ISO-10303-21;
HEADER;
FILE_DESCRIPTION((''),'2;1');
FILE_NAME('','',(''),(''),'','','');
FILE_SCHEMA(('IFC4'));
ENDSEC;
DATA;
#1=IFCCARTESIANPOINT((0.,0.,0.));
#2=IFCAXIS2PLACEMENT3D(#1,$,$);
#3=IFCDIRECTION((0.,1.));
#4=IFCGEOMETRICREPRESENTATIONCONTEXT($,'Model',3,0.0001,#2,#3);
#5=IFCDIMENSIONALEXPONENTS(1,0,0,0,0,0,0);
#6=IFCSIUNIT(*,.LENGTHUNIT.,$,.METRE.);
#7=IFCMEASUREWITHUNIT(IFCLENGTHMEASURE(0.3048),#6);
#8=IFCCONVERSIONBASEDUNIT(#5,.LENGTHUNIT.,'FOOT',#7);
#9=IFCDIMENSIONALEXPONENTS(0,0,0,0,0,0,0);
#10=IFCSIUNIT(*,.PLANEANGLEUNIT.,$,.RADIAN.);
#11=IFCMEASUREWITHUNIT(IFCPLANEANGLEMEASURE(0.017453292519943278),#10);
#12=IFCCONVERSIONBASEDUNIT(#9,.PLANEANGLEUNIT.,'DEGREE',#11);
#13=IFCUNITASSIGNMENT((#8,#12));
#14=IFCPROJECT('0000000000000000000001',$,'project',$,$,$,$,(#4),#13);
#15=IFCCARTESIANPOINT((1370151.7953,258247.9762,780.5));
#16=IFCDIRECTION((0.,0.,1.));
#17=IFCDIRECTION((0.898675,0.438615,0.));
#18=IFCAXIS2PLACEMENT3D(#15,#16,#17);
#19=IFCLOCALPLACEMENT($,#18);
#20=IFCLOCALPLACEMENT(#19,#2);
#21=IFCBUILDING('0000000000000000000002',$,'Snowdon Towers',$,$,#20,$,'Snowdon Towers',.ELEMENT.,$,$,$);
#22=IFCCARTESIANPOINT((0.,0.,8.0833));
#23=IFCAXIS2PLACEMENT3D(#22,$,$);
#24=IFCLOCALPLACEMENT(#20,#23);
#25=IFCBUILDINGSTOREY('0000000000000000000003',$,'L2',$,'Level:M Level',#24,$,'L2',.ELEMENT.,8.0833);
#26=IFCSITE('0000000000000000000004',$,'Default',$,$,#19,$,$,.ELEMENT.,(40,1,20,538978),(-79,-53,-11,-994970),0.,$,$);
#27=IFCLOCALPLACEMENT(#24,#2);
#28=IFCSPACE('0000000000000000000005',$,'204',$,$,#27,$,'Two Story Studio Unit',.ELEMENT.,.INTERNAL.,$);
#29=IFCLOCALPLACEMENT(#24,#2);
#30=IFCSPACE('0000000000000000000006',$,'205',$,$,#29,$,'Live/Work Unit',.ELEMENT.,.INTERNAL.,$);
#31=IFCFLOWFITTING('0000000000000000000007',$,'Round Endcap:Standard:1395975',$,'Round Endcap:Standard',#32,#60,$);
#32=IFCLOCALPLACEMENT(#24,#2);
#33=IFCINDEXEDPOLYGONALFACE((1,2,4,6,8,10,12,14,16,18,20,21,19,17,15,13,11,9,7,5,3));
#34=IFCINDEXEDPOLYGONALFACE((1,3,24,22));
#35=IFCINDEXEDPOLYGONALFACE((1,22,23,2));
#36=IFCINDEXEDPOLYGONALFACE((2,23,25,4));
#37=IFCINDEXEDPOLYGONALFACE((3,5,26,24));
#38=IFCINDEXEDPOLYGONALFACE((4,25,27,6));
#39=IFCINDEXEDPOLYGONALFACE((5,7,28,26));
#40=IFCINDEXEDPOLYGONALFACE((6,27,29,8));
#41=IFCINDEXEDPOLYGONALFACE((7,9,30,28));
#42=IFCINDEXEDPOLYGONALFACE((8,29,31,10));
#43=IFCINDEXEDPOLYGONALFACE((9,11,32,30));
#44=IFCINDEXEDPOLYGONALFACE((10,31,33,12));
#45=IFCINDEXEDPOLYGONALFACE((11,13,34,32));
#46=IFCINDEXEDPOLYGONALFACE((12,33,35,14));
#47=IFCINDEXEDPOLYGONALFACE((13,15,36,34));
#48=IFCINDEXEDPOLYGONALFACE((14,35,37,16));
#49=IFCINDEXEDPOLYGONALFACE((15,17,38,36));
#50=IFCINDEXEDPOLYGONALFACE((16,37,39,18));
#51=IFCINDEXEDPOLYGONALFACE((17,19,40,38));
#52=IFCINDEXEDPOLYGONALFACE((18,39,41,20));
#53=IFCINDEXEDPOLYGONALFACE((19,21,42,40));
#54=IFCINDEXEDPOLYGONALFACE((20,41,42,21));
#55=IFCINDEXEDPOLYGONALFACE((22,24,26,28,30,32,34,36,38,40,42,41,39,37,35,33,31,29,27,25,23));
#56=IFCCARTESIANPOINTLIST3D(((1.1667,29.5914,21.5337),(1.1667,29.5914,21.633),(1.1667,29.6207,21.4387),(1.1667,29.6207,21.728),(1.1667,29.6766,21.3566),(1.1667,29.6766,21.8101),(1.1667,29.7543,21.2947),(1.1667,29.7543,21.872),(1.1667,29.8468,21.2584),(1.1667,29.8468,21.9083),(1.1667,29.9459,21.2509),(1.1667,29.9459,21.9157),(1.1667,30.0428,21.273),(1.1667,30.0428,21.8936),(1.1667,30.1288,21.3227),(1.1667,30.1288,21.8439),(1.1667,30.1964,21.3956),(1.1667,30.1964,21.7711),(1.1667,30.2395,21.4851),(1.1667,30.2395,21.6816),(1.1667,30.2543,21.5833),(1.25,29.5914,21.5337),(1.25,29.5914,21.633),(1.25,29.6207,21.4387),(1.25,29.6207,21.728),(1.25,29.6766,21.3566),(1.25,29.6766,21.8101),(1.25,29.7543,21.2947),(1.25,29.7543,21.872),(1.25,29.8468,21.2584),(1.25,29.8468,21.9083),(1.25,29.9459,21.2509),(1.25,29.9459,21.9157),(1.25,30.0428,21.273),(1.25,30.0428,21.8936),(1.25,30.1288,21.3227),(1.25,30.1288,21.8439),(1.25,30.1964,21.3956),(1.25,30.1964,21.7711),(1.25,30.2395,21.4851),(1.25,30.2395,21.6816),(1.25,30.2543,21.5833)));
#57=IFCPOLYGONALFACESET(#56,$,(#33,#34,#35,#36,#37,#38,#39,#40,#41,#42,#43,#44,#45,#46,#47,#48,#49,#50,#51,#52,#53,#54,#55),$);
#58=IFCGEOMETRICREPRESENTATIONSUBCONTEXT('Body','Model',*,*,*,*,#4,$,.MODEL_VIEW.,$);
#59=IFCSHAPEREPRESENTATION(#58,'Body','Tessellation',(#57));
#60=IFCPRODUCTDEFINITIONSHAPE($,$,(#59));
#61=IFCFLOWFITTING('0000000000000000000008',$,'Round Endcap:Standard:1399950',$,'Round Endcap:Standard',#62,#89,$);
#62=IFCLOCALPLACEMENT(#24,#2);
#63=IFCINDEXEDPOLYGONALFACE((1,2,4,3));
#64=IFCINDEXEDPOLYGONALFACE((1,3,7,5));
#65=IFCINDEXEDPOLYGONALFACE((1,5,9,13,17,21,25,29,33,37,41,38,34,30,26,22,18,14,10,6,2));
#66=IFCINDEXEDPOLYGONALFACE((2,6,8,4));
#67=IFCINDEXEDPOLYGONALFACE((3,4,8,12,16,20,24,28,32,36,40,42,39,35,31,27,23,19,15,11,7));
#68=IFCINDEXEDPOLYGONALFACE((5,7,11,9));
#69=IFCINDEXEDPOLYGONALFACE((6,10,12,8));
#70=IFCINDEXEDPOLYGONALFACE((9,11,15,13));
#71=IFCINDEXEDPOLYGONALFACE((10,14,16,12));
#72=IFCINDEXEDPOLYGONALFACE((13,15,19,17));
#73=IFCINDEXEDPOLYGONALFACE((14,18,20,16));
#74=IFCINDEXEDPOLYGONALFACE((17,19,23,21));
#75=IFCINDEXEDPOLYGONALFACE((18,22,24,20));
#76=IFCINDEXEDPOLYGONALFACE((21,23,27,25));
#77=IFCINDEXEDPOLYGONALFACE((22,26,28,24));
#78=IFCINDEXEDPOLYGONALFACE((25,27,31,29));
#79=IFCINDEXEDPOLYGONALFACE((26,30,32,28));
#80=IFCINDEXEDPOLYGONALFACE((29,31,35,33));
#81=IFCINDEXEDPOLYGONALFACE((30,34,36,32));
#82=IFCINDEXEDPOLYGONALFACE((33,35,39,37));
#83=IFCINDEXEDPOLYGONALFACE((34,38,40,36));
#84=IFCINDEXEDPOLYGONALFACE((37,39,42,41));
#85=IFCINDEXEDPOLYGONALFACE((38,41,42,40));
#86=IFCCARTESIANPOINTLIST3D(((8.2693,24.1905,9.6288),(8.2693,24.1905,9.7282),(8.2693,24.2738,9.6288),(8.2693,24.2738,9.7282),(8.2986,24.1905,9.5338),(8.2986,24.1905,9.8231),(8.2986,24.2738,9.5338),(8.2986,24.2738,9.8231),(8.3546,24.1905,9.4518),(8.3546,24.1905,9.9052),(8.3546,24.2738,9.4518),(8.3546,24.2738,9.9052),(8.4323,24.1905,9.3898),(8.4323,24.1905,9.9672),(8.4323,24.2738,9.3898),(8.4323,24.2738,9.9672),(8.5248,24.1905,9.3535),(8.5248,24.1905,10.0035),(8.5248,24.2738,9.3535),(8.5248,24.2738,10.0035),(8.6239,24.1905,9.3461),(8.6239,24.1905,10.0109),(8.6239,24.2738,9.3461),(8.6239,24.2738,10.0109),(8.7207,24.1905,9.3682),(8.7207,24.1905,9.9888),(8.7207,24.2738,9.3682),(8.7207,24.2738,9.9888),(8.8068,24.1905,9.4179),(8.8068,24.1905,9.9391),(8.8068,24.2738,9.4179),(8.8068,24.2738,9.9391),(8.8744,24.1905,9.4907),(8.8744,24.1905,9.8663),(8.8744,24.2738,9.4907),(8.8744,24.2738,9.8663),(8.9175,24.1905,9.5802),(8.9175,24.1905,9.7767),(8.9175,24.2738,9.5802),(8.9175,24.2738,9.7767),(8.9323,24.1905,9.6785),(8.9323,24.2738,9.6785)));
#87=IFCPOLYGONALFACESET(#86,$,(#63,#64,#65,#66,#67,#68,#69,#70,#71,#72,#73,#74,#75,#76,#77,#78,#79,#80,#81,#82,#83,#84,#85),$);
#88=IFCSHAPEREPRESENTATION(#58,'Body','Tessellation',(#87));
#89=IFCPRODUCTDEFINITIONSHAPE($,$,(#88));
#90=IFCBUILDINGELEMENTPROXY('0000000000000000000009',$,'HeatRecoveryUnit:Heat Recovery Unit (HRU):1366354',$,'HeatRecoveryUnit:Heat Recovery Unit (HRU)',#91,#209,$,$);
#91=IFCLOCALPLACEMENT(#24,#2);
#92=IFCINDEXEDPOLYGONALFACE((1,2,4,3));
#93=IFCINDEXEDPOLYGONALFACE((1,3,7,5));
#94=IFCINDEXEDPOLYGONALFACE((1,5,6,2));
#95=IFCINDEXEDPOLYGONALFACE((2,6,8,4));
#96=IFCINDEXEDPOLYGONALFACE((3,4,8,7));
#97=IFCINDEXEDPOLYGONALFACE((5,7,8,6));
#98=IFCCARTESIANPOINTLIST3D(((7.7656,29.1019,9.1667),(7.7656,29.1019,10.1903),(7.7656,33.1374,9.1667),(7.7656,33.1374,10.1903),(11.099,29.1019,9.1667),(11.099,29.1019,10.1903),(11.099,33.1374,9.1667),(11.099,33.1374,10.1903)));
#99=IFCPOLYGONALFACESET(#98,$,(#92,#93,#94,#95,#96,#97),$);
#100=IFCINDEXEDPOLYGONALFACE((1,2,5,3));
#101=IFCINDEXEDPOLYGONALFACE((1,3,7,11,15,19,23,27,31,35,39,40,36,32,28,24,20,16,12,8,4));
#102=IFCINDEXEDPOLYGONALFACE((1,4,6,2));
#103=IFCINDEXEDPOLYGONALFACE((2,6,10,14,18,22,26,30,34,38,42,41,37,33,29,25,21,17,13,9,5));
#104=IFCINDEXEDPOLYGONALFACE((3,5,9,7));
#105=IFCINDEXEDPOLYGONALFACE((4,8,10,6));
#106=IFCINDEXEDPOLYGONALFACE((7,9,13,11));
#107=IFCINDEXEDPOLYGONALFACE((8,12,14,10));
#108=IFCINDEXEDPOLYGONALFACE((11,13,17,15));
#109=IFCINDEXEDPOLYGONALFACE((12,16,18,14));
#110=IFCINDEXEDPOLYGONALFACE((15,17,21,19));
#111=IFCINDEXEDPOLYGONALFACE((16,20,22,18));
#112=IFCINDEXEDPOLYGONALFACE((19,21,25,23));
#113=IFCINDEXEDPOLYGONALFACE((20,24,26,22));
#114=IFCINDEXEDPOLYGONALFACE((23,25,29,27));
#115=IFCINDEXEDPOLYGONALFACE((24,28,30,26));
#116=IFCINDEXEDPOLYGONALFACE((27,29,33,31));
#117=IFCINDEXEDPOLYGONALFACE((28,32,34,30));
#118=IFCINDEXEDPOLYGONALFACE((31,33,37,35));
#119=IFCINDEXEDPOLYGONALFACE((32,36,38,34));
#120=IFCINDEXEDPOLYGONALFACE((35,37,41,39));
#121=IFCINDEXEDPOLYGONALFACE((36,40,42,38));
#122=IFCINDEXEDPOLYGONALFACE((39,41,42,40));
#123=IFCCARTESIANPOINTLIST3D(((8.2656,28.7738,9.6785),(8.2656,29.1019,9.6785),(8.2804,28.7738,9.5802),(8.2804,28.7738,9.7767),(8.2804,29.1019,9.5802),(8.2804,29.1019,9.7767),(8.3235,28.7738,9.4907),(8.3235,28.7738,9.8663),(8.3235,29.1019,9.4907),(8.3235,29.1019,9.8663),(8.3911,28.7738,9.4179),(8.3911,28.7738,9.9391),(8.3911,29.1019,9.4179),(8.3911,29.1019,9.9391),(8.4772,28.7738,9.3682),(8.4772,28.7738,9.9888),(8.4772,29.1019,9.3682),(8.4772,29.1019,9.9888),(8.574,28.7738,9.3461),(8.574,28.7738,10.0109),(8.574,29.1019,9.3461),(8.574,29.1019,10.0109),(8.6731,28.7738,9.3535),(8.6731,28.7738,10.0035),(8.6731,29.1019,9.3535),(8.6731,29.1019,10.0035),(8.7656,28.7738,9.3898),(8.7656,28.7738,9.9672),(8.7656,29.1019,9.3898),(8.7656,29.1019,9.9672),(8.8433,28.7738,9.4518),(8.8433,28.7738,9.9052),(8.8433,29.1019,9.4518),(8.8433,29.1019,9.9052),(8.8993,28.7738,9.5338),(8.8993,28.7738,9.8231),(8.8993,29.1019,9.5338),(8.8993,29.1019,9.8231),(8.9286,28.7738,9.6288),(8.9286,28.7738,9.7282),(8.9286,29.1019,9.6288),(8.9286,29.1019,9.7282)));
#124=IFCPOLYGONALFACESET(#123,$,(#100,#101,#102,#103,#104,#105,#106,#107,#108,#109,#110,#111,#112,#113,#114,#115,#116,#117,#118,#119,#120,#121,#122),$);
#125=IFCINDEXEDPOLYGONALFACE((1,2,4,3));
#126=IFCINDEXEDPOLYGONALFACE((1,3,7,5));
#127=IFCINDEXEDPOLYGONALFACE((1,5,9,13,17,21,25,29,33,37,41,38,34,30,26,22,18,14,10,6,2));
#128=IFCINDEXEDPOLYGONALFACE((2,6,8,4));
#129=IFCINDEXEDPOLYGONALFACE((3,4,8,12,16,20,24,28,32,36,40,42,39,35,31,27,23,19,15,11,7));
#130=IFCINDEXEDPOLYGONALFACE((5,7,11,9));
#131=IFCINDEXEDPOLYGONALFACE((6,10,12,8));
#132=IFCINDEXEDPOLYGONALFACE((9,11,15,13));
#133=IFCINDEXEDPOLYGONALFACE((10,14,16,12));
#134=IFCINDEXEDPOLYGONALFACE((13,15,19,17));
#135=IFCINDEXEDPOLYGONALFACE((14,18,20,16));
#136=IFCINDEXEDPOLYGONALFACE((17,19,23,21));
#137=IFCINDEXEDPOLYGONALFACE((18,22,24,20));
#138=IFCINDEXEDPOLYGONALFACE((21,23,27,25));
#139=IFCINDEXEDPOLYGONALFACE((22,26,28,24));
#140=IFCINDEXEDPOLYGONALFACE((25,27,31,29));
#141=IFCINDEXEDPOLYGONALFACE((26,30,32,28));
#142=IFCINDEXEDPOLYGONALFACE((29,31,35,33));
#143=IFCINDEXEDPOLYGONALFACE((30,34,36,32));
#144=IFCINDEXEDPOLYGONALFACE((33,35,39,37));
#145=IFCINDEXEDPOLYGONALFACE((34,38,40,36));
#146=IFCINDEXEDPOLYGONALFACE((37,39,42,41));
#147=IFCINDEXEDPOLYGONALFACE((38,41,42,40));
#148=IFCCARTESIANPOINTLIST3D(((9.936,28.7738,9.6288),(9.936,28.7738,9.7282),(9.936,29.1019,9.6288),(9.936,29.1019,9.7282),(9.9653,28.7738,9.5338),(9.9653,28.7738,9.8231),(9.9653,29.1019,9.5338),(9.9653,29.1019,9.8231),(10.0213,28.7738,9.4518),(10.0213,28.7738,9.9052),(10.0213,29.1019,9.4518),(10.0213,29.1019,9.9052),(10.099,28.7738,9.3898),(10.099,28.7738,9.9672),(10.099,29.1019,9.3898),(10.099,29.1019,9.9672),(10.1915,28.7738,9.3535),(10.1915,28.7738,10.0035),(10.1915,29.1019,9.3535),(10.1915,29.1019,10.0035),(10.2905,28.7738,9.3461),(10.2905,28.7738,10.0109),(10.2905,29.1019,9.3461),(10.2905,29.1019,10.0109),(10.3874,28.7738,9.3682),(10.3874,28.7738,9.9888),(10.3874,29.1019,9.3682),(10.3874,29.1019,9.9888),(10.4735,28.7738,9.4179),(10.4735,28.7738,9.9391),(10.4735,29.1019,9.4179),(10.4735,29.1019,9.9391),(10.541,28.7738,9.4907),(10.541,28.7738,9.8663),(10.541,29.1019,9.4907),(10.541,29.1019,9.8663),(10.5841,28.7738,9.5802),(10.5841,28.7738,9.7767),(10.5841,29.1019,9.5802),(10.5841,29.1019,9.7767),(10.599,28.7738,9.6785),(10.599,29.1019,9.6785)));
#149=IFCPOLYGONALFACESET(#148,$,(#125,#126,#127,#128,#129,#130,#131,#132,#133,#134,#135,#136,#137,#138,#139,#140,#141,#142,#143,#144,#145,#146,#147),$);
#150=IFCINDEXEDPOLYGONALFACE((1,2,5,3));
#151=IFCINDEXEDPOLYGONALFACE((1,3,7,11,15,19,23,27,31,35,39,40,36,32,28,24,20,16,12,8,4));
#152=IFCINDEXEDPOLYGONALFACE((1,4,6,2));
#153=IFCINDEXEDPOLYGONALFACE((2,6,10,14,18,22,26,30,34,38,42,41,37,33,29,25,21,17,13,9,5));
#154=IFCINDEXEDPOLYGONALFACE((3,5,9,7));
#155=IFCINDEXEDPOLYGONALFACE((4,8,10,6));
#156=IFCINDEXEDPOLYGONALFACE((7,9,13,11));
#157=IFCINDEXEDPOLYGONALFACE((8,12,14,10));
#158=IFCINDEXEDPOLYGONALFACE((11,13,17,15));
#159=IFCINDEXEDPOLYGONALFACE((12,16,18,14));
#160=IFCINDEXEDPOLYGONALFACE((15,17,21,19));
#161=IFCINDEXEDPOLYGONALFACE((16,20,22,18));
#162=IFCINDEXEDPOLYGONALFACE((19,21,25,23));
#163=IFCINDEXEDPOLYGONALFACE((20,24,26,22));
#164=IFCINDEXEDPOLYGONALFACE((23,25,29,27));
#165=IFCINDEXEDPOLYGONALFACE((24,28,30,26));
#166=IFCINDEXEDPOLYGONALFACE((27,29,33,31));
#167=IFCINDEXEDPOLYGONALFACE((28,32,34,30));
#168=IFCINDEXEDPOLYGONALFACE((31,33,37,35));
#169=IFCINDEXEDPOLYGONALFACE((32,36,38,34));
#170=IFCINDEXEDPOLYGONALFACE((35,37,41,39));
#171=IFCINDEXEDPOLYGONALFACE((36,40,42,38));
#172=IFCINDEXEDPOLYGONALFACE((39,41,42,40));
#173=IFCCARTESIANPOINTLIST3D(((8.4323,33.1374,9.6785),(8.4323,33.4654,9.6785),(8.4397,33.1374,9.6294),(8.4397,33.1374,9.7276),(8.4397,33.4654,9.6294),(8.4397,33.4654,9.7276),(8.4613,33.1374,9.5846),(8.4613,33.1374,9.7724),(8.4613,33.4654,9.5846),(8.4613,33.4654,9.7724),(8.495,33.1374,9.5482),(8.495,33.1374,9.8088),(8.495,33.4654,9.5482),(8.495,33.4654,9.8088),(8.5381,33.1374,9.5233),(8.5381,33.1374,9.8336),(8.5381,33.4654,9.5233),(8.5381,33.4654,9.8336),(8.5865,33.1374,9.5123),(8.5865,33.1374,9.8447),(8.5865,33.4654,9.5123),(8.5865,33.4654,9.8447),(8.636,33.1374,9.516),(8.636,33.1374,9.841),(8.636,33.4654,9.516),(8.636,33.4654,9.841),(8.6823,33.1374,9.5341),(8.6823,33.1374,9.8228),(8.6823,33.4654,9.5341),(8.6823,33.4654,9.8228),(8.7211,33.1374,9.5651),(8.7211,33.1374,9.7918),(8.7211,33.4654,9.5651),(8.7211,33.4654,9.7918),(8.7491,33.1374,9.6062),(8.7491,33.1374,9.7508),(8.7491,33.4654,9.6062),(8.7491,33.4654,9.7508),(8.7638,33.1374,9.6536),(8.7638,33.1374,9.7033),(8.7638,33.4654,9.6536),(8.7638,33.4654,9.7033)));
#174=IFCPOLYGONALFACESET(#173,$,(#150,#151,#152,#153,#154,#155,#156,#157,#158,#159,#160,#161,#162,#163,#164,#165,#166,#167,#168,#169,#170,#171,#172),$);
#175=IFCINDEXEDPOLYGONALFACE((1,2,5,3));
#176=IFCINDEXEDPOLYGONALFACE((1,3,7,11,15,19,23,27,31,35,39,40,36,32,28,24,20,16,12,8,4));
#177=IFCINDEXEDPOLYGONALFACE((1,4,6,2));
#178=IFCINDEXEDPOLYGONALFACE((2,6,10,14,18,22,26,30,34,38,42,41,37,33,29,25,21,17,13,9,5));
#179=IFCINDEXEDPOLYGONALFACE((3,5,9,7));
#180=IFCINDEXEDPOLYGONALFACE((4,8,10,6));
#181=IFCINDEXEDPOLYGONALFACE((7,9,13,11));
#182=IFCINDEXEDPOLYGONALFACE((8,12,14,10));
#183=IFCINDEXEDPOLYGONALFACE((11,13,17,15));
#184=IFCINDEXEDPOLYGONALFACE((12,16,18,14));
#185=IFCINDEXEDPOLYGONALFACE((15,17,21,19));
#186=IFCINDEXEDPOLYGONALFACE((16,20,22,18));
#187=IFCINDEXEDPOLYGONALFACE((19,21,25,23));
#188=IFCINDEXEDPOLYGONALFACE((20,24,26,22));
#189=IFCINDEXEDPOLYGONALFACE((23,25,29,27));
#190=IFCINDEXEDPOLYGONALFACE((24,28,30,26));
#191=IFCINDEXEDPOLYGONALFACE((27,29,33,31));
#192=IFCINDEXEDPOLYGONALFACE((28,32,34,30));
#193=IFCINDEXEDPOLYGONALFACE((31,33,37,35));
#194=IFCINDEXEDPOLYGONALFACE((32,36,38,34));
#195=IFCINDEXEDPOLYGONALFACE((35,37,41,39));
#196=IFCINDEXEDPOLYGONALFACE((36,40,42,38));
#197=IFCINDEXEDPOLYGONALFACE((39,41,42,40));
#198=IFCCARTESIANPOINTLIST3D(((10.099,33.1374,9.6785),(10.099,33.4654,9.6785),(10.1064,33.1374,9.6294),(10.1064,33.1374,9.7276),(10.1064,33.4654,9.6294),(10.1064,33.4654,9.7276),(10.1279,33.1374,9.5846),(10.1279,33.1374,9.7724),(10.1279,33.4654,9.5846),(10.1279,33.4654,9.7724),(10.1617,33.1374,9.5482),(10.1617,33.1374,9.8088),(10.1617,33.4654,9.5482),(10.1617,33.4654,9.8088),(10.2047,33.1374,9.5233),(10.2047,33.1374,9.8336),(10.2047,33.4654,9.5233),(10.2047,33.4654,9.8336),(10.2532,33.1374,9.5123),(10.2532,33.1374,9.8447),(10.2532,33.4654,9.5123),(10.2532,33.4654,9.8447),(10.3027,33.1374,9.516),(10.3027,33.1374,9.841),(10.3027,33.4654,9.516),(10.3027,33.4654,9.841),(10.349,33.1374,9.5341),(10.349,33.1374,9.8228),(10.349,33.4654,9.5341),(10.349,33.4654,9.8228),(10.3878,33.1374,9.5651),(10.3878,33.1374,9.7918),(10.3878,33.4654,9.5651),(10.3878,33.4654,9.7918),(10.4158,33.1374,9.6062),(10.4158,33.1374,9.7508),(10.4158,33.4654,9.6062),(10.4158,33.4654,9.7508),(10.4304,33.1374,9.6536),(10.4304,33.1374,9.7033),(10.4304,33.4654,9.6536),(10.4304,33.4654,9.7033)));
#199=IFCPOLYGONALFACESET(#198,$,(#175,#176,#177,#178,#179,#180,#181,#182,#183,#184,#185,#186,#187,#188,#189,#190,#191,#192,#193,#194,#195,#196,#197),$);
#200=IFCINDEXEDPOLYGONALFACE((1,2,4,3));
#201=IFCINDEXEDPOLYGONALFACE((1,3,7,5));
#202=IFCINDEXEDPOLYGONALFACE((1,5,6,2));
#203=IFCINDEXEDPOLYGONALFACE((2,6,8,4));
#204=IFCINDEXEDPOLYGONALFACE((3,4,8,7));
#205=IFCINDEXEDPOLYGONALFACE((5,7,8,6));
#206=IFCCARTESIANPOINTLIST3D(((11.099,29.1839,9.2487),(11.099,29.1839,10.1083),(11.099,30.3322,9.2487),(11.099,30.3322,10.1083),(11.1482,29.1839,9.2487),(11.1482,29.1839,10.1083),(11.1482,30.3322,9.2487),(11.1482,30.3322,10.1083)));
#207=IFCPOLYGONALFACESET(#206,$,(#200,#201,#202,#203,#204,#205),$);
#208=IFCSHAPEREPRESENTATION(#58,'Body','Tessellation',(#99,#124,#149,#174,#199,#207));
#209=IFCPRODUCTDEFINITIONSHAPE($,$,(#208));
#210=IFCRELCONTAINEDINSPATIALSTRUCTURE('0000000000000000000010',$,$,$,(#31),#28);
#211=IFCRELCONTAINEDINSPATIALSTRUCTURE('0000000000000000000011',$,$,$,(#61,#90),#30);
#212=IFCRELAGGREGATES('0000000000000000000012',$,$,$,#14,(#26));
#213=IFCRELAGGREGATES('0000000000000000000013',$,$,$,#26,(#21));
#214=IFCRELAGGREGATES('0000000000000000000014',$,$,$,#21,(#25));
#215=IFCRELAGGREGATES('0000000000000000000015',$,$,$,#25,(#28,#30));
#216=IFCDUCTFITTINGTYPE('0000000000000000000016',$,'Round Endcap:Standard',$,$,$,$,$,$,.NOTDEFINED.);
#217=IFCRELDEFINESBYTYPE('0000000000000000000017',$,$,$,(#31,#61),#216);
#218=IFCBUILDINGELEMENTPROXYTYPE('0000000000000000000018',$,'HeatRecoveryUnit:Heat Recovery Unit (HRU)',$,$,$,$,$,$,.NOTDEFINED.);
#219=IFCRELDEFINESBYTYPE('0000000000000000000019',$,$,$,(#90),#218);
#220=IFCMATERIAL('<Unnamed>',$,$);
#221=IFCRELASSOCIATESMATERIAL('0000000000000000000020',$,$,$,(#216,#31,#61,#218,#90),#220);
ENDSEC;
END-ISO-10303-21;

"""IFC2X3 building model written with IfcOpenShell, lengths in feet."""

from ifc_helpers import new_model, entity, si_unit, converted_unit, direction, frame, frame_2d, origin, origin_2d_with_axis, place, context, subcontext, project, spatial, rectangle, circle, extrude, source, transform, mapped, material, type_object, type_shapes, element, save


model = new_model("IFC2X3")

# Units and contexts
model_context = context("Model", 3, precision=0.0001, world=origin(), true_north=direction((0.0, 1.0)))
body_context = subcontext(model_context, "Body", "Model", "MODEL_VIEW")
ifc_project = project(units=[converted_unit("LENGTHUNIT", "FOOT", entity("IfcLengthMeasure", 0.3048), si_unit("LENGTHUNIT", "METRE"), dimensions=[1, 0, 0, 0, 0, 0, 0]), converted_unit("PLANEANGLEUNIT", "DEGREE", entity("IfcPlaneAngleMeasure", 0.017453292519943278), si_unit("PLANEANGLEUNIT", "RADIAN"), dimensions=[0, 0, 0, 0, 0, 0, 0])], contexts=[model_context])

# Site, building, storey
site_placement = place(None, frame((1370151.7953, 258247.9762, 780.5), z_axis=(0.0, 0.0, 1.0), x_axis=(0.898675, 0.438615, 0.0)))
site = spatial("IfcSite", under=ifc_project, at=site_placement, Name="Default", CompositionType="ELEMENT", RefLatitude=(40, 1, 20, 538978), RefLongitude=(-79, -53, -11, -994970), RefElevation=0.0)
building_placement = place(site_placement, origin())
building = spatial("IfcBuilding", under=site, at=building_placement, Name="Snowdon Towers", LongName="Snowdon Towers", CompositionType="ELEMENT")
storey_placement = place(building_placement, frame((0.0, 0.0, 8.0833)))
storey = spatial("IfcBuildingStorey", under=building, at=storey_placement, Name="L2", ObjectType="Level:M Level", LongName="L2", CompositionType="ELEMENT", Elevation=8.0833)

# Shared definitions
ifc_material = material(Name="<Unnamed>")

# Shared definitions
space_1_placement = place(storey_placement, origin())
space_1 = spatial("IfcSpace", under=storey, at=space_1_placement, Name="204", LongName="Two Story Studio Unit", CompositionType="ELEMENT", InteriorOrExteriorSpace="INTERNAL")

# Flow fitting
duct_fitting_type = type_object("IfcDuctFittingType", Name="Round Endcap:Standard", PredefinedType="NOTDEFINED", material=ifc_material)
shared_shape_1 = source(origin(), body_context, "Body", "SweptSolid", [
    extrude(circle(Radius=0.3333, at=frame_2d((0.0, 0.0), x_axis=(1.0, 0.0))), frame((0.0, 0.0, 0.0), z_axis=(1.0, 0.0, 0.0), x_axis=(0.0, 1.0, 0.0)), (0.0, 0.0, 1.0), 0.0833),
])
type_shapes(duct_fitting_type, [shared_shape_1])
flow_fitting_1_placement = place(space_1_placement, frame((1.1667, 29.921, 21.5833)))
element("IfcFlowFitting", 1, at=flow_fitting_1_placement, inside=space_1, type_object=duct_fitting_type, material=ifc_material, Name="Round Endcap:Standard:1395975", ObjectType="Round Endcap:Standard", context=body_context, shape_type="MappedRepresentation", body=[
    mapped(shared_shape_1, transform((0.0, 0.0, 0.0), scale=1.0)),
])

# Shared definitions
space_2_placement = place(storey_placement, origin())
space_2 = spatial("IfcSpace", under=storey, at=space_2_placement, Name="205", LongName="Live/Work Unit", CompositionType="ELEMENT", InteriorOrExteriorSpace="INTERNAL")

# Flow fitting
flow_fitting_2_placement = place(space_2_placement, frame((8.599, 24.2738, 9.6785), z_axis=(0.0, 0.0, 1.0), x_axis=(0.0, -1.0, 0.0)))
element("IfcFlowFitting", 2, at=flow_fitting_2_placement, inside=space_2, type_object=duct_fitting_type, material=ifc_material, Name="Round Endcap:Standard:1399950", ObjectType="Round Endcap:Standard", context=body_context, shape_type="MappedRepresentation", body=[
    mapped(shared_shape_1, transform((0.0, 0.0, 0.0), scale=1.0)),
])

# Building element proxy
building_element_proxy_type = type_object("IfcBuildingElementProxyType", Name="HeatRecoveryUnit:Heat Recovery Unit (HRU)", PredefinedType="NOTDEFINED", material=ifc_material)
shared_shape_2 = source(origin(), body_context, "Body", "SweptSolid", [
    extrude(rectangle(XDim=3.3333, YDim=4.0354, at=origin_2d_with_axis()), frame((0.0, 0.0, 0.0), z_axis=(0.0, 0.0, 1.0), x_axis=(-1.0, 0.0, 0.0)), (0.0, 0.0, 1.0), 1.0236),
    extrude(circle(Radius=0.3333, at=frame_2d((0.0, 0.0), x_axis=(1.0, 0.0))), frame((-0.8333, -2.3458, 0.5118), z_axis=(0.0, 1.0, 0.0), x_axis=(-1.0, 0.0, 0.0)), (0.0, 0.0, 1.0), 0.3281),
    extrude(circle(Radius=0.3333, at=frame_2d((0.0, 0.0), x_axis=(1.0, 0.0))), frame((0.8333, -2.3458, 0.5118), z_axis=(0.0, 1.0, 0.0), x_axis=(1.0, 0.0, 0.0)), (0.0, 0.0, 1.0), 0.3281),
    extrude(circle(Radius=0.1667, at=frame_2d((0.0, 0.0), x_axis=(1.0, 0.0))), frame((-0.8333, 2.0177, 0.5118), z_axis=(0.0, 1.0, 0.0), x_axis=(-1.0, 0.0, 0.0)), (0.0, 0.0, 1.0), 0.3281),
    extrude(circle(Radius=0.1667, at=frame_2d((0.0, 0.0), x_axis=(1.0, 0.0))), frame((0.8333, 2.0177, 0.5118), z_axis=(0.0, 1.0, 0.0), x_axis=(-1.0, 0.0, 0.0)), (0.0, 0.0, 1.0), 0.3281),
    extrude(rectangle(XDim=0.0492, YDim=1.1483, at=origin_2d_with_axis()), frame((1.6913, -1.3615, 0.082), z_axis=(0.0, 0.0, 1.0), x_axis=(-1.0, 0.0, 0.0)), (0.0, 0.0, 1.0), 0.8596),
])
type_shapes(building_element_proxy_type, [shared_shape_2])
proxy_placement = place(space_2_placement, frame((9.4323, 31.1196, 9.1667)))
element("IfcBuildingElementProxy", 3, at=proxy_placement, inside=space_2, type_object=building_element_proxy_type, material=ifc_material, Name="HeatRecoveryUnit:Heat Recovery Unit (HRU):1366354", ObjectType="HeatRecoveryUnit:Heat Recovery Unit (HRU)", context=body_context, shape_type="MappedRepresentation", body=[
    mapped(shared_shape_2, transform((0.0, 0.0, 0.0), scale=1.0)),
])

save(model, "model.ifc")
